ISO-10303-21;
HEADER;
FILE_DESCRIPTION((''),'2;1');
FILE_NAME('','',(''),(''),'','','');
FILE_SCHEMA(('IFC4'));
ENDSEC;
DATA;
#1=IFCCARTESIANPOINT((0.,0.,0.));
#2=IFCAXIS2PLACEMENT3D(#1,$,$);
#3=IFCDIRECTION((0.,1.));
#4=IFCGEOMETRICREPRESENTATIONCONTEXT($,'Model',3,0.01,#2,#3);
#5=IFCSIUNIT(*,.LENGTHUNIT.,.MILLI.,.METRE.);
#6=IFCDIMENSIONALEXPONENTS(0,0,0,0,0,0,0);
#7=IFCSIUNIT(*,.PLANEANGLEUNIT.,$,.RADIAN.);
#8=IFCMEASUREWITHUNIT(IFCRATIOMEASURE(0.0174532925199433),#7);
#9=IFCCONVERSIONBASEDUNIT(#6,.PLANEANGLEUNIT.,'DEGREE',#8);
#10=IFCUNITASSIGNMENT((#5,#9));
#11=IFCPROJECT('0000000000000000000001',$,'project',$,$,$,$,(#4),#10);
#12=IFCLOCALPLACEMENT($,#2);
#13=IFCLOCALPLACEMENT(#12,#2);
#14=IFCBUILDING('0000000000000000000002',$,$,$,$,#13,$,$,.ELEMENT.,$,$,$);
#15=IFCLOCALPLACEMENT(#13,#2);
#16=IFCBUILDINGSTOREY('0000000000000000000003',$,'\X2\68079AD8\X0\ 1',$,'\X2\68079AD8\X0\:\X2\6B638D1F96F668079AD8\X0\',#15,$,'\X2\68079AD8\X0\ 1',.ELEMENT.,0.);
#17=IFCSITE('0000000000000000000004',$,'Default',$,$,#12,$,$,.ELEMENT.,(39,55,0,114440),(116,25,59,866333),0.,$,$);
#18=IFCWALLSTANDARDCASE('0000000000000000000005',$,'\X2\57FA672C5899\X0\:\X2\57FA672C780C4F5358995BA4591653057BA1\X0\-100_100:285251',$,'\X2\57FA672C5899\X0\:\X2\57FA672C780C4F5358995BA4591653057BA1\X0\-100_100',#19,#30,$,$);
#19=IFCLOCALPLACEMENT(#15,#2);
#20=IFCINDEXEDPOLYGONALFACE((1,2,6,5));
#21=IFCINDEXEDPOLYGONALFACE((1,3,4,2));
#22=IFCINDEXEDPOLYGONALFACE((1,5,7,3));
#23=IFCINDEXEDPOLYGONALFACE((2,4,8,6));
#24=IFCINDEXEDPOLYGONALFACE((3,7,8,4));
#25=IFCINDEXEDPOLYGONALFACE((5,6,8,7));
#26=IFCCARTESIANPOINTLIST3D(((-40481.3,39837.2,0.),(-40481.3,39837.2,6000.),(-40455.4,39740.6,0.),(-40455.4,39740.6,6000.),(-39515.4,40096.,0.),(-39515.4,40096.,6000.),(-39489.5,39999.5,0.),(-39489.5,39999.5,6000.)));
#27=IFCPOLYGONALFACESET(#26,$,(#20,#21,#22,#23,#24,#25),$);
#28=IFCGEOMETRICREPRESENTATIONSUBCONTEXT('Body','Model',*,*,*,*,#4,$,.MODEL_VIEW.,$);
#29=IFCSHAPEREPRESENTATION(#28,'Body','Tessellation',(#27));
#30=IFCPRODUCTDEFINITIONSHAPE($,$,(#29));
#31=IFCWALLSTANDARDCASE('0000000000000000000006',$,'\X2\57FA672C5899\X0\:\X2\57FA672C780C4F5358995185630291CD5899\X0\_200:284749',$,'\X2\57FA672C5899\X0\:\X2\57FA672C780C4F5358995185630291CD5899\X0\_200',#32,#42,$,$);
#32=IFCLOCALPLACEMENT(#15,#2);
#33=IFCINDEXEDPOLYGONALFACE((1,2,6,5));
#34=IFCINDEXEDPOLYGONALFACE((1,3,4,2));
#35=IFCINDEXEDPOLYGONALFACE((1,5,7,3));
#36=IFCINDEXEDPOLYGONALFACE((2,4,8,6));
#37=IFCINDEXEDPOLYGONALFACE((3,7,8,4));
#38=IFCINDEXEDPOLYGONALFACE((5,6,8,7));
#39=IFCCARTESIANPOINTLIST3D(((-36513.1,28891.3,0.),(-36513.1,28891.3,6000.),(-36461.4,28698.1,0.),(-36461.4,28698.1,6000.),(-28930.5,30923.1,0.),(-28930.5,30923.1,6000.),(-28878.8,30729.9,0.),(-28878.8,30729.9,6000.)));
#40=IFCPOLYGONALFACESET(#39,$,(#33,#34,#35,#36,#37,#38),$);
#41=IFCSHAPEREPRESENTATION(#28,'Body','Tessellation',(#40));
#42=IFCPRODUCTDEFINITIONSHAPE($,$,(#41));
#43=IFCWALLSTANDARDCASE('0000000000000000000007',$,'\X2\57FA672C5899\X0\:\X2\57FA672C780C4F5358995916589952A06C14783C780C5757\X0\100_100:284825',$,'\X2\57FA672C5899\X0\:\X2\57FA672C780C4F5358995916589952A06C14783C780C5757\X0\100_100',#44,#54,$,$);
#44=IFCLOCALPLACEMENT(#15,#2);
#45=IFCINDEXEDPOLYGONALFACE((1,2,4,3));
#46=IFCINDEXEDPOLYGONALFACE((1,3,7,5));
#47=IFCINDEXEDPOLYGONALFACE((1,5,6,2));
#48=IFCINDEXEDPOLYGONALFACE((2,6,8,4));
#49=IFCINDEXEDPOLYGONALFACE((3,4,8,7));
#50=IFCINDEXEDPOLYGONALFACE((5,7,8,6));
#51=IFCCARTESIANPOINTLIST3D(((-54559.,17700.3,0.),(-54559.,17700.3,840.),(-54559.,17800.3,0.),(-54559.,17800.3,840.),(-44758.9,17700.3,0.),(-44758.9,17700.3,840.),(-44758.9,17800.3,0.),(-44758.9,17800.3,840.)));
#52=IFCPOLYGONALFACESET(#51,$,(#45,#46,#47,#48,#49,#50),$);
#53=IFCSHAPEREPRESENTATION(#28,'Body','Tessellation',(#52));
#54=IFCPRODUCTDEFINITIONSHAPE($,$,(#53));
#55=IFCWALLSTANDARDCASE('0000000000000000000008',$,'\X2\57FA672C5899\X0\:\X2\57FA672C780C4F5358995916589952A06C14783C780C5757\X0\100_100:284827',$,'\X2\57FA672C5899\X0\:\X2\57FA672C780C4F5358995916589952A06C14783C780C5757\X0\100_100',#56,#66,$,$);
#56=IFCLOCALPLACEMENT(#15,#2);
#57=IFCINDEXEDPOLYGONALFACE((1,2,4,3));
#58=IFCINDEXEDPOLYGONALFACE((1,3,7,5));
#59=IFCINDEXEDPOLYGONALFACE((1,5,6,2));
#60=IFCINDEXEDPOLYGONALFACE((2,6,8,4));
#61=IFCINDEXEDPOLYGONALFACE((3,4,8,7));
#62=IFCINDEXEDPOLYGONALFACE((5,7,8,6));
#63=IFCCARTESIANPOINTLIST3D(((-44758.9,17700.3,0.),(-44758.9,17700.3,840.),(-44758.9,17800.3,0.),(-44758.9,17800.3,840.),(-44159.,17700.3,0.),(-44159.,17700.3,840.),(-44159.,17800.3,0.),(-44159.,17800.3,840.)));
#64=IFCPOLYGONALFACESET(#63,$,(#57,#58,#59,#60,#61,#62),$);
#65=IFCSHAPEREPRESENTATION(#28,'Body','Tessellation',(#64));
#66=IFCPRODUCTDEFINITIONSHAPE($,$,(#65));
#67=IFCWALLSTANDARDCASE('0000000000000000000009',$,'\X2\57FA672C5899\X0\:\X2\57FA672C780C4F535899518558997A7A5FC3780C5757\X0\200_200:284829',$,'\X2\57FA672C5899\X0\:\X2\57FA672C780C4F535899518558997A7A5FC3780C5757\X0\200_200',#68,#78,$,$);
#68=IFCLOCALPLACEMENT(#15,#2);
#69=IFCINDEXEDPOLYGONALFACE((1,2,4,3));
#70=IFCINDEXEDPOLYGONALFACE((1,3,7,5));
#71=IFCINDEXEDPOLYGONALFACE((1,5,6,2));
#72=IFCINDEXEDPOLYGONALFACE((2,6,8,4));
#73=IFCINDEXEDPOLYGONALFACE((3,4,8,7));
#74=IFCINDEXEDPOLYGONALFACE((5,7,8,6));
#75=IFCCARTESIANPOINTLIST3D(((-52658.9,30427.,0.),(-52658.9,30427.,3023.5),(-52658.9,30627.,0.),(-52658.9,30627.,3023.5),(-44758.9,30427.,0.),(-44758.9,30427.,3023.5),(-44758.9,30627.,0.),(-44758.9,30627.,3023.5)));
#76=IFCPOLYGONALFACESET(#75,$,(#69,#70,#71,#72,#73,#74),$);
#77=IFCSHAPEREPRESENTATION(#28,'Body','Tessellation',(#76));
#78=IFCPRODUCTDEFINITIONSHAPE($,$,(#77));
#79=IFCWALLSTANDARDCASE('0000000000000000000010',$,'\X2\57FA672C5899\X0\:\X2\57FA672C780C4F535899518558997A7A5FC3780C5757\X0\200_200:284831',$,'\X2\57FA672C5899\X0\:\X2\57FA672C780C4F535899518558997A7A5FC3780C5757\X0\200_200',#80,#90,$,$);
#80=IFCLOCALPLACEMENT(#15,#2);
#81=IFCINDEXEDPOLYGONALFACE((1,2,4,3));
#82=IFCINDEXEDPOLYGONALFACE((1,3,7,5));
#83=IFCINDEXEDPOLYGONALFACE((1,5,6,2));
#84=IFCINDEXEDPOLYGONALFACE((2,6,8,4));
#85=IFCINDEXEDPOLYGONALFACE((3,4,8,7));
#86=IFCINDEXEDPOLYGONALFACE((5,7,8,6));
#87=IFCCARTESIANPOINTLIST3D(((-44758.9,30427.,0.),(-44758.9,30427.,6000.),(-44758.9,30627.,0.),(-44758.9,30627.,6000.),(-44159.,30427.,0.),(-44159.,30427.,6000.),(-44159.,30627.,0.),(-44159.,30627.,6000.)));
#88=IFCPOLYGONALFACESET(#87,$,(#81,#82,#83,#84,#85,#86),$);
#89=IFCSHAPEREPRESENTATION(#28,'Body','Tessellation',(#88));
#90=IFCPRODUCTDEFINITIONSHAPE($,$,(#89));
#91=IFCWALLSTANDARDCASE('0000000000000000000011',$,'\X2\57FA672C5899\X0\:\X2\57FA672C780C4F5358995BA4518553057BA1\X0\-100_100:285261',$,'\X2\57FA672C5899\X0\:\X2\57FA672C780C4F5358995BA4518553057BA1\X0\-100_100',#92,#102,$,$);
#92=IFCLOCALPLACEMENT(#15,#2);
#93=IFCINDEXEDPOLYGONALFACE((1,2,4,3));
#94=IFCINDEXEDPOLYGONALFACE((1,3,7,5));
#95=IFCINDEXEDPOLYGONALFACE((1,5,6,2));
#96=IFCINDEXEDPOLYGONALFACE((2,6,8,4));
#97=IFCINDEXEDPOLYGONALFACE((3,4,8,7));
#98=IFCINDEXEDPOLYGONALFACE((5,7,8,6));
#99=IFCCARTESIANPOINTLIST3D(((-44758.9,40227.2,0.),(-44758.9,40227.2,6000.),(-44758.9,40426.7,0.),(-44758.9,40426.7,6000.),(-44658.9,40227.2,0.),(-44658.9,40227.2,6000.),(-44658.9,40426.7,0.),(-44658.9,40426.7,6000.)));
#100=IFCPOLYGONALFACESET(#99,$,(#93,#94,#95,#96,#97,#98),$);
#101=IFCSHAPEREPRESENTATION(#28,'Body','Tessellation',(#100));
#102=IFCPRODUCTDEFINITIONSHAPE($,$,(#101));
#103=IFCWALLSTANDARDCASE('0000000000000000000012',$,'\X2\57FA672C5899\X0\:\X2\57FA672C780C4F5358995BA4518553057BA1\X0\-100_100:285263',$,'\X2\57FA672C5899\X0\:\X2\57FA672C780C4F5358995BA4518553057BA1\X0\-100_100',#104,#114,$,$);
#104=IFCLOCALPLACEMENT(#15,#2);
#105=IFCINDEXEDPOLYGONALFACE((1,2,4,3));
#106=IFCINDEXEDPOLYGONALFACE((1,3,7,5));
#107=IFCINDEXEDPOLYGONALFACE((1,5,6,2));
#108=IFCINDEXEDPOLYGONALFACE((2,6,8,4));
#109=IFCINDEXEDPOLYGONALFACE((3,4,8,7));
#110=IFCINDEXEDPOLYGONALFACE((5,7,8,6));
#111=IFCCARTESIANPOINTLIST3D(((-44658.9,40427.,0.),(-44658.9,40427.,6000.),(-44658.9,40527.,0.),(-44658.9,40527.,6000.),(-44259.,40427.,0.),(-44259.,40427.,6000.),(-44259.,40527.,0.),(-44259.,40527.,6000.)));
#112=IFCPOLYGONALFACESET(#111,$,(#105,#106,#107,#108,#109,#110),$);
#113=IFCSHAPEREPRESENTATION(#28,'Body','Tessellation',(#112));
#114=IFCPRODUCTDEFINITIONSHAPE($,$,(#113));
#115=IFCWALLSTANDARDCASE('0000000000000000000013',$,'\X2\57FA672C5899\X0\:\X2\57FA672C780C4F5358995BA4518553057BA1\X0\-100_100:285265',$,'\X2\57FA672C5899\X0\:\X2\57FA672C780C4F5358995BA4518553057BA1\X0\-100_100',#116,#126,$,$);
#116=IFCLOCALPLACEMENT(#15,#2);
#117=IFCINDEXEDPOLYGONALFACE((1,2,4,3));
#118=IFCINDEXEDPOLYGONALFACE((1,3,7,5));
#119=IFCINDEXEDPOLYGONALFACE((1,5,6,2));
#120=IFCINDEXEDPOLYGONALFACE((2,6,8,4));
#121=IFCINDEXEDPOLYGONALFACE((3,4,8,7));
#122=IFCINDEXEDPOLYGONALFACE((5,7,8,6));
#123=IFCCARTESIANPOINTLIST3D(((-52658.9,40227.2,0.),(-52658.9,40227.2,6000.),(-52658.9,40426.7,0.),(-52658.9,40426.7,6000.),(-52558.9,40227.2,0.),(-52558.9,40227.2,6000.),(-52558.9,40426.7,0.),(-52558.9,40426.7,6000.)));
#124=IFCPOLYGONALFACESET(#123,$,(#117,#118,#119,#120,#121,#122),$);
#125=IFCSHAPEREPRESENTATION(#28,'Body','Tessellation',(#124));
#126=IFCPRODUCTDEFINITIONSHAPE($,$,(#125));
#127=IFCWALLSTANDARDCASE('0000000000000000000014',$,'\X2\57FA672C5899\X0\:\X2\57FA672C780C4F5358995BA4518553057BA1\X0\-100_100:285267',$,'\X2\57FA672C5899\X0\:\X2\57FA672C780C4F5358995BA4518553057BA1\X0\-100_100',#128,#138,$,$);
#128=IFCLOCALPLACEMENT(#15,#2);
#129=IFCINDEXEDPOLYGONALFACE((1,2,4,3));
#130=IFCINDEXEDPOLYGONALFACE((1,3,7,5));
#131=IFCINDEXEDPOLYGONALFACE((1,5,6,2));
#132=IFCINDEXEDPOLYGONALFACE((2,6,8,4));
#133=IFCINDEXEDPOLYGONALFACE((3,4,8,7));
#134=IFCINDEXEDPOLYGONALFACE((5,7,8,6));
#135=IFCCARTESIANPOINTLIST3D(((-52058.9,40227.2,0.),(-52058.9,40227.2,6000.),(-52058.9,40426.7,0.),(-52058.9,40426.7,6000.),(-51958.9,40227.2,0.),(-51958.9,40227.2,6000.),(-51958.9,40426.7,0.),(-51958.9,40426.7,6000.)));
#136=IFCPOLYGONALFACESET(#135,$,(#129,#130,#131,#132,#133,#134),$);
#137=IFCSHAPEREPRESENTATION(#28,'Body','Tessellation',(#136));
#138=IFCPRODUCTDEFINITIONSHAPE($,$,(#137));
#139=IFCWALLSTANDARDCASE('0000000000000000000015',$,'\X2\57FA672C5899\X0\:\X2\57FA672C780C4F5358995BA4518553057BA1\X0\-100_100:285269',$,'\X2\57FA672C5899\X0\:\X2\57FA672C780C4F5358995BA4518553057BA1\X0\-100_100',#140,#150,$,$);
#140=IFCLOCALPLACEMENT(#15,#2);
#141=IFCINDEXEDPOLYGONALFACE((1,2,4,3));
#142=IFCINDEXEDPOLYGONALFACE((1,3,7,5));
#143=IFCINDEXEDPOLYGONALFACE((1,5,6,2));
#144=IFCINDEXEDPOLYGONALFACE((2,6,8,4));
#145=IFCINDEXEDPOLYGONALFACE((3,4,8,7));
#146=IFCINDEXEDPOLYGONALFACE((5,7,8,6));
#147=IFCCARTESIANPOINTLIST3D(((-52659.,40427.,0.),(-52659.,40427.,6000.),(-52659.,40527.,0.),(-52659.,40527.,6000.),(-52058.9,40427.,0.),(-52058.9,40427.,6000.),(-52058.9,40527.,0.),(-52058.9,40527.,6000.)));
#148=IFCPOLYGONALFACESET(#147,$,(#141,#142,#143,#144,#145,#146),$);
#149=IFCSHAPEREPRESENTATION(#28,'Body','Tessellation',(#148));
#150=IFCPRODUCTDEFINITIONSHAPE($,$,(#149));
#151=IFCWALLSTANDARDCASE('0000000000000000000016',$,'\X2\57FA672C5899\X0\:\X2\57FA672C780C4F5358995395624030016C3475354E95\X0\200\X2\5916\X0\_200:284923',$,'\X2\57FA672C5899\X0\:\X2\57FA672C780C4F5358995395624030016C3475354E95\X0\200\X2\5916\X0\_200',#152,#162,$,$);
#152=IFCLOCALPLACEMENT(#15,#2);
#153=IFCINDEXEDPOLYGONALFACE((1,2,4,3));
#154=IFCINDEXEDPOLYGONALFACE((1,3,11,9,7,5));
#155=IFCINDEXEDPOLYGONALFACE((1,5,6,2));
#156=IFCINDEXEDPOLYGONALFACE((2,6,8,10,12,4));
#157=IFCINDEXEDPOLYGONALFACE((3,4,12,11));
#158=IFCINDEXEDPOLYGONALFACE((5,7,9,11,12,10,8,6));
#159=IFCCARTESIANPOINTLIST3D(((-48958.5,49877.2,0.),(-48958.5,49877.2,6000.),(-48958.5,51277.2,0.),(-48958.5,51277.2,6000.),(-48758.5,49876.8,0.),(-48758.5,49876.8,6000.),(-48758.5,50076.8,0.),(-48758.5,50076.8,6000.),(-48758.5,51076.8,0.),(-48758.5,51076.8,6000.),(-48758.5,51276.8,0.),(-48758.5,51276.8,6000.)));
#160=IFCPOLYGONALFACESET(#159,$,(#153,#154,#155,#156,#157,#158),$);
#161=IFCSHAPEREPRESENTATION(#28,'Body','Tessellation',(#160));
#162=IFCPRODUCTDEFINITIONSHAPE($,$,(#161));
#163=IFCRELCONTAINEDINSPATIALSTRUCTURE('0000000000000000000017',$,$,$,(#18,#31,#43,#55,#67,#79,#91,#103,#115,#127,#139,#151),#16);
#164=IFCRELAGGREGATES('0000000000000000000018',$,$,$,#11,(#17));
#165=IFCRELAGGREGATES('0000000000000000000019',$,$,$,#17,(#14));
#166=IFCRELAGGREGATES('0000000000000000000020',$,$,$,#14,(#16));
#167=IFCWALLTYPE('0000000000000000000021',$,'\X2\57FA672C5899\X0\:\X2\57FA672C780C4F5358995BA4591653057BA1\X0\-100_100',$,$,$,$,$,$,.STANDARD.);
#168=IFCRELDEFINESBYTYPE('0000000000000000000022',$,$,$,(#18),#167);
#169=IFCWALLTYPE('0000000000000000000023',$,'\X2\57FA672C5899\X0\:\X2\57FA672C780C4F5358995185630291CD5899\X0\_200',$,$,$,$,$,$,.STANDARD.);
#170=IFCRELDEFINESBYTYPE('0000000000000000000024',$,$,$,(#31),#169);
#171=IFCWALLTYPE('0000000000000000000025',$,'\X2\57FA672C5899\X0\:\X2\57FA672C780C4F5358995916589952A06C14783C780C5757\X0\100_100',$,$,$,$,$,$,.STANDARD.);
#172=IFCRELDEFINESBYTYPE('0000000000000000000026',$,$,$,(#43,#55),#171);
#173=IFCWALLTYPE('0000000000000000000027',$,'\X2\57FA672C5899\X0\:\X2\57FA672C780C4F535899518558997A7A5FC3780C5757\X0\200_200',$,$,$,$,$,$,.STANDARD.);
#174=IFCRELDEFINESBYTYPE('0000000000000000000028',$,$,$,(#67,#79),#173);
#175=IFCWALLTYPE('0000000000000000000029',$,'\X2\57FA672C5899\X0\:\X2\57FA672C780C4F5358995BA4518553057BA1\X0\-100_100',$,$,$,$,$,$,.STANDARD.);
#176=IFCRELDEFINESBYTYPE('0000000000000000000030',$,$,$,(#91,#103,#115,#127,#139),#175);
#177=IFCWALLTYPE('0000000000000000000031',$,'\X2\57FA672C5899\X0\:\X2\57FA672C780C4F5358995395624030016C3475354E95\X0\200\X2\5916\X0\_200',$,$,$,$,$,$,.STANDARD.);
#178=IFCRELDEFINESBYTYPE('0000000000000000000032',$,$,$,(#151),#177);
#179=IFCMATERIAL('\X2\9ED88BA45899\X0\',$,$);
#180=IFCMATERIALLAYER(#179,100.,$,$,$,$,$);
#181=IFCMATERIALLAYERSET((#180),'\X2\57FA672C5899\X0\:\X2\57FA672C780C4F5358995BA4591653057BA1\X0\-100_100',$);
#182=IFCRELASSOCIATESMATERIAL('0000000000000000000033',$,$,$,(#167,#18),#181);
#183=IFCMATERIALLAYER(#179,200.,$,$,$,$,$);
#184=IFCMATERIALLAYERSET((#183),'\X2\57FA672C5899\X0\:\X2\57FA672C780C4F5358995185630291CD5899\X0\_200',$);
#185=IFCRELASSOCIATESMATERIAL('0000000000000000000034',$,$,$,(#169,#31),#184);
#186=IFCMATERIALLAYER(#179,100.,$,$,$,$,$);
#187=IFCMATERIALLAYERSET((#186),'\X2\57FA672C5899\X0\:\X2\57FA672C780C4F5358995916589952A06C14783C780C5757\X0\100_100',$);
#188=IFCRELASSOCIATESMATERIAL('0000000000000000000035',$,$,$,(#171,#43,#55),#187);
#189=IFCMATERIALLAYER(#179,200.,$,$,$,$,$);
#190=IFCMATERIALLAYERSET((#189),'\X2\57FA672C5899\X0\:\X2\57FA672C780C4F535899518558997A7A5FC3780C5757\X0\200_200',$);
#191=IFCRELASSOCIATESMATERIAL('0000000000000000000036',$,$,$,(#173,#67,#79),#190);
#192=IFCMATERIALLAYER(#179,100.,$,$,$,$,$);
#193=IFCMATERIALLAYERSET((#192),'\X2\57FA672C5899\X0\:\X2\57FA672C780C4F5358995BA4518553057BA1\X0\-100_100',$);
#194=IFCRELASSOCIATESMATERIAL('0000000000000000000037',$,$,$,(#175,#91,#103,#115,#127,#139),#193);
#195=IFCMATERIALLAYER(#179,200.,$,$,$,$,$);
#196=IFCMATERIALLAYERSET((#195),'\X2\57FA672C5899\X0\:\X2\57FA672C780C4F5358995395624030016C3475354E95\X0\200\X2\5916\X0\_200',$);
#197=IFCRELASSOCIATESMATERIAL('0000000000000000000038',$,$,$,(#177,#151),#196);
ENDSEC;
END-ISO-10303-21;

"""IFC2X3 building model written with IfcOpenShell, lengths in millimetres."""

from ifc_helpers import new_model, entity, si_unit, converted_unit, direction, frame, frame_2d, origin, place, context, subcontext, project, spatial, polyline, rectangle, outline, extrude, material, layer, layer_set, layer_usage, type_object, element, save


model = new_model("IFC2X3")

# Units and contexts
model_context = context("Model", 3, precision=0.01, world=origin(), true_north=direction((0.0, 1.0)))
body_context = subcontext(model_context, "Body", "Model", "MODEL_VIEW")
ifc_project = project(units=[si_unit("LENGTHUNIT", "METRE", prefix="MILLI"), converted_unit("PLANEANGLEUNIT", "DEGREE", entity("IfcRatioMeasure", 0.0174532925199433), si_unit("PLANEANGLEUNIT", "RADIAN"), dimensions=[0, 0, 0, 0, 0, 0, 0])], contexts=[model_context])

# Site, building, storey
site_placement = place(None, origin())
site = spatial("IfcSite", under=ifc_project, at=site_placement, Name="Default", CompositionType="ELEMENT", RefLatitude=(39, 55, 0, 114440), RefLongitude=(116, 25, 59, 866333), RefElevation=0.0)
building_placement = place(site_placement, origin())
building = spatial("IfcBuilding", under=site, at=building_placement, CompositionType="ELEMENT")
storey_placement = place(building_placement, origin())
storey = spatial("IfcBuildingStorey", under=building, at=storey_placement, Name="标高 1", ObjectType="标高:正负零标高", LongName="标高 1", CompositionType="ELEMENT", Elevation=0.0)

# Walls
ifc_material = material(Name="默认墙")
ifc_layer_1 = layer(ifc_material, 100.0)
ifc_layer_set_1 = layer_set([ifc_layer_1], Name="基本墙:基本砌体墙室外包管-100_100")
wall_type_1 = type_object("IfcWallType", Name="基本墙:基本砌体墙室外包管-100_100", PredefinedType="STANDARD", material=ifc_layer_set_1)
ifc_layer_usage_1 = layer_usage(ifc_layer_set_1, "AXIS2", "NEGATIVE", 50.0)
wall_1_placement = place(building_placement, frame((-39502.5, 40047.7, 0.0), z_axis=(0.0, 0.0, 1.0), x_axis=(-0.965926, -0.258819, 0.0)))
element("IfcWallStandardCase", 1, at=wall_1_placement, inside=storey, type_object=wall_type_1, material=ifc_layer_usage_1, Name="基本墙:基本砌体墙室外包管-100_100:285251", ObjectType="基本墙:基本砌体墙室外包管-100_100", context=body_context, shape_type="SweptSolid", body=[
    extrude(rectangle(XDim=999.9, YDim=100.0, at=frame_2d((500.0, 0.0), x_axis=(-1.0, 0.0))), origin(), (0.0, 0.0, 1.0), 6000.0),
])
ifc_layer_2 = layer(ifc_material, 200.0)
ifc_layer_set_2 = layer_set([ifc_layer_2], Name="基本墙:基本砌体墙内挂重墙_200")
ifc_layer_usage_2 = layer_usage(ifc_layer_set_2, "AXIS2", "NEGATIVE", 100.0)
wall_type_2 = type_object("IfcWallType", Name="基本墙:基本砌体墙内挂重墙_200", PredefinedType="STANDARD", material=ifc_layer_set_2)
wall_2_placement = place(building_placement, frame((-36487.2, 28794.7, 0.0), z_axis=(0.0, 0.0, 1.0), x_axis=(0.965926, 0.258819, 0.0)))
element("IfcWallStandardCase", 2, at=wall_2_placement, inside=storey, type_object=wall_type_2, material=ifc_layer_usage_2, Name="基本墙:基本砌体墙内挂重墙_200:284749", ObjectType="基本墙:基本砌体墙内挂重墙_200", context=body_context, shape_type="SweptSolid", body=[
    extrude(rectangle(XDim=7850.1, YDim=200.0, at=frame_2d((3925.0, 0.0), x_axis=(-1.0, 0.0))), origin(), (0.0, 0.0, 1.0), 6000.0),
])
ifc_layer_3 = layer(ifc_material, 100.0)
ifc_layer_set_3 = layer_set([ifc_layer_3], Name="基本墙:基本砌体墙外墙加气砼砌块100_100")
ifc_layer_usage_3 = layer_usage(ifc_layer_set_3, "AXIS2", "NEGATIVE", 50.0)
wall_type_3 = type_object("IfcWallType", Name="基本墙:基本砌体墙外墙加气砼砌块100_100", PredefinedType="STANDARD", material=ifc_layer_set_3)
wall_3_placement = place(building_placement, frame((-54559.0, 17750.3, 0.0)))
element("IfcWallStandardCase", 3, at=wall_3_placement, inside=storey, type_object=wall_type_3, material=ifc_layer_usage_3, Name="基本墙:基本砌体墙外墙加气砼砌块100_100:284825", ObjectType="基本墙:基本砌体墙外墙加气砼砌块100_100", context=body_context, shape_type="SweptSolid", body=[
    extrude(rectangle(XDim=9800.1, YDim=100.0, at=frame_2d((4900.1, 0.0), x_axis=(-1.0, 0.0))), origin(), (0.0, 0.0, 1.0), 840.0),
])
ifc_layer_usage_4 = layer_usage(ifc_layer_set_3, "AXIS2", "NEGATIVE", 50.0)
wall_4_placement = place(building_placement, frame((-44758.9, 17750.3, 0.0)))
element("IfcWallStandardCase", 4, at=wall_4_placement, inside=storey, type_object=wall_type_3, material=ifc_layer_usage_4, Name="基本墙:基本砌体墙外墙加气砼砌块100_100:284827", ObjectType="基本墙:基本砌体墙外墙加气砼砌块100_100", context=body_context, shape_type="SweptSolid", body=[
    extrude(rectangle(XDim=599.9, YDim=100.0, at=frame_2d((299.9, 0.0), x_axis=(-1.0, 0.0))), origin(), (0.0, 0.0, 1.0), 840.0),
])
ifc_layer_4 = layer(ifc_material, 200.0)
ifc_layer_set_4 = layer_set([ifc_layer_4], Name="基本墙:基本砌体墙内墙空心砌块200_200")
ifc_layer_usage_5 = layer_usage(ifc_layer_set_4, "AXIS2", "NEGATIVE", 100.0)
wall_type_4 = type_object("IfcWallType", Name="基本墙:基本砌体墙内墙空心砌块200_200", PredefinedType="STANDARD", material=ifc_layer_set_4)
wall_5_placement = place(building_placement, frame((-52658.9, 30527.0, 0.0)))
element("IfcWallStandardCase", 5, at=wall_5_placement, inside=storey, type_object=wall_type_4, material=ifc_layer_usage_5, Name="基本墙:基本砌体墙内墙空心砌块200_200:284829", ObjectType="基本墙:基本砌体墙内墙空心砌块200_200", context=body_context, shape_type="SweptSolid", body=[
    extrude(rectangle(XDim=7900.0, YDim=200.0, at=frame_2d((3950.0, 0.0), x_axis=(-1.0, 0.0))), origin(), (0.0, 0.0, 1.0), 3023.5),
])
ifc_layer_usage_6 = layer_usage(ifc_layer_set_4, "AXIS2", "NEGATIVE", 100.0)
wall_6_placement = place(building_placement, frame((-44758.9, 30527.0, 0.0)))
element("IfcWallStandardCase", 6, at=wall_6_placement, inside=storey, type_object=wall_type_4, material=ifc_layer_usage_6, Name="基本墙:基本砌体墙内墙空心砌块200_200:284831", ObjectType="基本墙:基本砌体墙内墙空心砌块200_200", context=body_context, shape_type="SweptSolid", body=[
    extrude(rectangle(XDim=599.9, YDim=200.0, at=frame_2d((299.9, 0.0), x_axis=(-1.0, 0.0))), origin(), (0.0, 0.0, 1.0), 6000.0),
])
ifc_layer_5 = layer(ifc_material, 100.0)
ifc_layer_set_5 = layer_set([ifc_layer_5], Name="基本墙:基本砌体墙室内包管-100_100")
ifc_layer_usage_7 = layer_usage(ifc_layer_set_5, "AXIS2", "NEGATIVE", 50.0)
wall_type_5 = type_object("IfcWallType", Name="基本墙:基本砌体墙室内包管-100_100", PredefinedType="STANDARD", material=ifc_layer_set_5)
wall_7_placement = place(building_placement, frame((-44708.9, 40426.7, 0.0), z_axis=(0.0, 0.0, 1.0), x_axis=(0.0, -1.0, 0.0)))
element("IfcWallStandardCase", 7, at=wall_7_placement, inside=storey, type_object=wall_type_5, material=ifc_layer_usage_7, Name="基本墙:基本砌体墙室内包管-100_100:285261", ObjectType="基本墙:基本砌体墙室内包管-100_100", context=body_context, shape_type="SweptSolid", body=[
    extrude(rectangle(XDim=199.5, YDim=100.0, at=frame_2d((99.8, 0.0), x_axis=(-1.0, 0.0))), origin(), (0.0, 0.0, 1.0), 6000.0),
])
ifc_layer_usage_8 = layer_usage(ifc_layer_set_5, "AXIS2", "NEGATIVE", 50.0)
wall_8_placement = place(building_placement, frame((-44658.9, 40477.0, 0.0)))
element("IfcWallStandardCase", 8, at=wall_8_placement, inside=storey, type_object=wall_type_5, material=ifc_layer_usage_8, Name="基本墙:基本砌体墙室内包管-100_100:285263", ObjectType="基本墙:基本砌体墙室内包管-100_100", context=body_context, shape_type="SweptSolid", body=[
    extrude(rectangle(XDim=399.9, YDim=100.0, at=frame_2d((199.9, 0.0), x_axis=(-1.0, 0.0))), origin(), (0.0, 0.0, 1.0), 6000.0),
])
ifc_layer_usage_9 = layer_usage(ifc_layer_set_5, "AXIS2", "NEGATIVE", 50.0)
wall_9_placement = place(building_placement, frame((-52608.9, 40426.7, 0.0), z_axis=(0.0, 0.0, 1.0), x_axis=(0.0, -1.0, 0.0)))
element("IfcWallStandardCase", 9, at=wall_9_placement, inside=storey, type_object=wall_type_5, material=ifc_layer_usage_9, Name="基本墙:基本砌体墙室内包管-100_100:285265", ObjectType="基本墙:基本砌体墙室内包管-100_100", context=body_context, shape_type="SweptSolid", body=[
    extrude(rectangle(XDim=199.5, YDim=100.0, at=frame_2d((99.8, 0.0), x_axis=(-1.0, 0.0))), origin(), (0.0, 0.0, 1.0), 6000.0),
])
ifc_layer_usage_10 = layer_usage(ifc_layer_set_5, "AXIS2", "NEGATIVE", 50.0)
wall_10_placement = place(building_placement, frame((-52008.9, 40426.7, 0.0), z_axis=(0.0, 0.0, 1.0), x_axis=(0.0, -1.0, 0.0)))
element("IfcWallStandardCase", 10, at=wall_10_placement, inside=storey, type_object=wall_type_5, material=ifc_layer_usage_10, Name="基本墙:基本砌体墙室内包管-100_100:285267", ObjectType="基本墙:基本砌体墙室内包管-100_100", context=body_context, shape_type="SweptSolid", body=[
    extrude(rectangle(XDim=199.5, YDim=100.0, at=frame_2d((99.8, 0.0), x_axis=(-1.0, 0.0))), origin(), (0.0, 0.0, 1.0), 6000.0),
])
ifc_layer_usage_11 = layer_usage(ifc_layer_set_5, "AXIS2", "NEGATIVE", 50.0)
wall_11_placement = place(building_placement, frame((-52058.9, 40477.0, 0.0), z_axis=(0.0, 0.0, 1.0), x_axis=(-1.0, 0.0, 0.0)))
element("IfcWallStandardCase", 11, at=wall_11_placement, inside=storey, type_object=wall_type_5, material=ifc_layer_usage_11, Name="基本墙:基本砌体墙室内包管-100_100:285269", ObjectType="基本墙:基本砌体墙室内包管-100_100", context=body_context, shape_type="SweptSolid", body=[
    extrude(rectangle(XDim=600.1, YDim=100.0, at=frame_2d((300.1, 0.0), x_axis=(-1.0, 0.0))), origin(), (0.0, 0.0, 1.0), 6000.0),
])
ifc_layer_6 = layer(ifc_material, 200.0)
ifc_layer_set_6 = layer_set([ifc_layer_6], Name="基本墙:基本砌体墙厕所、水电井200外_200")
ifc_layer_usage_12 = layer_usage(ifc_layer_set_6, "AXIS2", "NEGATIVE", 100.0)
wall_type_6 = type_object("IfcWallType", Name="基本墙:基本砌体墙厕所、水电井200外_200", PredefinedType="STANDARD", material=ifc_layer_set_6)
wall_12_placement = place(building_placement, frame((-48858.5, 49876.8, 0.0), z_axis=(0.0, 0.0, 1.0), x_axis=(0.0, 1.0, 0.0)))
element("IfcWallStandardCase", 12, at=wall_12_placement, inside=storey, type_object=wall_type_6, material=ifc_layer_usage_12, Name="基本墙:基本砌体墙厕所、水电井200外_200:284923", ObjectType="基本墙:基本砌体墙厕所、水电井200外_200", context=body_context, shape_type="SweptSolid", body=[
    extrude(outline(polyline([(1400.0, -100.0), (1400.3, 100.0), (0.3, 100.0), (0.0, -100.0), (200.0, -100.0), (1200.0, -100.0), (1400.0, -100.0)])), origin(), (0.0, 0.0, 1.0), 6000.0),
])

save(model, "model.ifc")
